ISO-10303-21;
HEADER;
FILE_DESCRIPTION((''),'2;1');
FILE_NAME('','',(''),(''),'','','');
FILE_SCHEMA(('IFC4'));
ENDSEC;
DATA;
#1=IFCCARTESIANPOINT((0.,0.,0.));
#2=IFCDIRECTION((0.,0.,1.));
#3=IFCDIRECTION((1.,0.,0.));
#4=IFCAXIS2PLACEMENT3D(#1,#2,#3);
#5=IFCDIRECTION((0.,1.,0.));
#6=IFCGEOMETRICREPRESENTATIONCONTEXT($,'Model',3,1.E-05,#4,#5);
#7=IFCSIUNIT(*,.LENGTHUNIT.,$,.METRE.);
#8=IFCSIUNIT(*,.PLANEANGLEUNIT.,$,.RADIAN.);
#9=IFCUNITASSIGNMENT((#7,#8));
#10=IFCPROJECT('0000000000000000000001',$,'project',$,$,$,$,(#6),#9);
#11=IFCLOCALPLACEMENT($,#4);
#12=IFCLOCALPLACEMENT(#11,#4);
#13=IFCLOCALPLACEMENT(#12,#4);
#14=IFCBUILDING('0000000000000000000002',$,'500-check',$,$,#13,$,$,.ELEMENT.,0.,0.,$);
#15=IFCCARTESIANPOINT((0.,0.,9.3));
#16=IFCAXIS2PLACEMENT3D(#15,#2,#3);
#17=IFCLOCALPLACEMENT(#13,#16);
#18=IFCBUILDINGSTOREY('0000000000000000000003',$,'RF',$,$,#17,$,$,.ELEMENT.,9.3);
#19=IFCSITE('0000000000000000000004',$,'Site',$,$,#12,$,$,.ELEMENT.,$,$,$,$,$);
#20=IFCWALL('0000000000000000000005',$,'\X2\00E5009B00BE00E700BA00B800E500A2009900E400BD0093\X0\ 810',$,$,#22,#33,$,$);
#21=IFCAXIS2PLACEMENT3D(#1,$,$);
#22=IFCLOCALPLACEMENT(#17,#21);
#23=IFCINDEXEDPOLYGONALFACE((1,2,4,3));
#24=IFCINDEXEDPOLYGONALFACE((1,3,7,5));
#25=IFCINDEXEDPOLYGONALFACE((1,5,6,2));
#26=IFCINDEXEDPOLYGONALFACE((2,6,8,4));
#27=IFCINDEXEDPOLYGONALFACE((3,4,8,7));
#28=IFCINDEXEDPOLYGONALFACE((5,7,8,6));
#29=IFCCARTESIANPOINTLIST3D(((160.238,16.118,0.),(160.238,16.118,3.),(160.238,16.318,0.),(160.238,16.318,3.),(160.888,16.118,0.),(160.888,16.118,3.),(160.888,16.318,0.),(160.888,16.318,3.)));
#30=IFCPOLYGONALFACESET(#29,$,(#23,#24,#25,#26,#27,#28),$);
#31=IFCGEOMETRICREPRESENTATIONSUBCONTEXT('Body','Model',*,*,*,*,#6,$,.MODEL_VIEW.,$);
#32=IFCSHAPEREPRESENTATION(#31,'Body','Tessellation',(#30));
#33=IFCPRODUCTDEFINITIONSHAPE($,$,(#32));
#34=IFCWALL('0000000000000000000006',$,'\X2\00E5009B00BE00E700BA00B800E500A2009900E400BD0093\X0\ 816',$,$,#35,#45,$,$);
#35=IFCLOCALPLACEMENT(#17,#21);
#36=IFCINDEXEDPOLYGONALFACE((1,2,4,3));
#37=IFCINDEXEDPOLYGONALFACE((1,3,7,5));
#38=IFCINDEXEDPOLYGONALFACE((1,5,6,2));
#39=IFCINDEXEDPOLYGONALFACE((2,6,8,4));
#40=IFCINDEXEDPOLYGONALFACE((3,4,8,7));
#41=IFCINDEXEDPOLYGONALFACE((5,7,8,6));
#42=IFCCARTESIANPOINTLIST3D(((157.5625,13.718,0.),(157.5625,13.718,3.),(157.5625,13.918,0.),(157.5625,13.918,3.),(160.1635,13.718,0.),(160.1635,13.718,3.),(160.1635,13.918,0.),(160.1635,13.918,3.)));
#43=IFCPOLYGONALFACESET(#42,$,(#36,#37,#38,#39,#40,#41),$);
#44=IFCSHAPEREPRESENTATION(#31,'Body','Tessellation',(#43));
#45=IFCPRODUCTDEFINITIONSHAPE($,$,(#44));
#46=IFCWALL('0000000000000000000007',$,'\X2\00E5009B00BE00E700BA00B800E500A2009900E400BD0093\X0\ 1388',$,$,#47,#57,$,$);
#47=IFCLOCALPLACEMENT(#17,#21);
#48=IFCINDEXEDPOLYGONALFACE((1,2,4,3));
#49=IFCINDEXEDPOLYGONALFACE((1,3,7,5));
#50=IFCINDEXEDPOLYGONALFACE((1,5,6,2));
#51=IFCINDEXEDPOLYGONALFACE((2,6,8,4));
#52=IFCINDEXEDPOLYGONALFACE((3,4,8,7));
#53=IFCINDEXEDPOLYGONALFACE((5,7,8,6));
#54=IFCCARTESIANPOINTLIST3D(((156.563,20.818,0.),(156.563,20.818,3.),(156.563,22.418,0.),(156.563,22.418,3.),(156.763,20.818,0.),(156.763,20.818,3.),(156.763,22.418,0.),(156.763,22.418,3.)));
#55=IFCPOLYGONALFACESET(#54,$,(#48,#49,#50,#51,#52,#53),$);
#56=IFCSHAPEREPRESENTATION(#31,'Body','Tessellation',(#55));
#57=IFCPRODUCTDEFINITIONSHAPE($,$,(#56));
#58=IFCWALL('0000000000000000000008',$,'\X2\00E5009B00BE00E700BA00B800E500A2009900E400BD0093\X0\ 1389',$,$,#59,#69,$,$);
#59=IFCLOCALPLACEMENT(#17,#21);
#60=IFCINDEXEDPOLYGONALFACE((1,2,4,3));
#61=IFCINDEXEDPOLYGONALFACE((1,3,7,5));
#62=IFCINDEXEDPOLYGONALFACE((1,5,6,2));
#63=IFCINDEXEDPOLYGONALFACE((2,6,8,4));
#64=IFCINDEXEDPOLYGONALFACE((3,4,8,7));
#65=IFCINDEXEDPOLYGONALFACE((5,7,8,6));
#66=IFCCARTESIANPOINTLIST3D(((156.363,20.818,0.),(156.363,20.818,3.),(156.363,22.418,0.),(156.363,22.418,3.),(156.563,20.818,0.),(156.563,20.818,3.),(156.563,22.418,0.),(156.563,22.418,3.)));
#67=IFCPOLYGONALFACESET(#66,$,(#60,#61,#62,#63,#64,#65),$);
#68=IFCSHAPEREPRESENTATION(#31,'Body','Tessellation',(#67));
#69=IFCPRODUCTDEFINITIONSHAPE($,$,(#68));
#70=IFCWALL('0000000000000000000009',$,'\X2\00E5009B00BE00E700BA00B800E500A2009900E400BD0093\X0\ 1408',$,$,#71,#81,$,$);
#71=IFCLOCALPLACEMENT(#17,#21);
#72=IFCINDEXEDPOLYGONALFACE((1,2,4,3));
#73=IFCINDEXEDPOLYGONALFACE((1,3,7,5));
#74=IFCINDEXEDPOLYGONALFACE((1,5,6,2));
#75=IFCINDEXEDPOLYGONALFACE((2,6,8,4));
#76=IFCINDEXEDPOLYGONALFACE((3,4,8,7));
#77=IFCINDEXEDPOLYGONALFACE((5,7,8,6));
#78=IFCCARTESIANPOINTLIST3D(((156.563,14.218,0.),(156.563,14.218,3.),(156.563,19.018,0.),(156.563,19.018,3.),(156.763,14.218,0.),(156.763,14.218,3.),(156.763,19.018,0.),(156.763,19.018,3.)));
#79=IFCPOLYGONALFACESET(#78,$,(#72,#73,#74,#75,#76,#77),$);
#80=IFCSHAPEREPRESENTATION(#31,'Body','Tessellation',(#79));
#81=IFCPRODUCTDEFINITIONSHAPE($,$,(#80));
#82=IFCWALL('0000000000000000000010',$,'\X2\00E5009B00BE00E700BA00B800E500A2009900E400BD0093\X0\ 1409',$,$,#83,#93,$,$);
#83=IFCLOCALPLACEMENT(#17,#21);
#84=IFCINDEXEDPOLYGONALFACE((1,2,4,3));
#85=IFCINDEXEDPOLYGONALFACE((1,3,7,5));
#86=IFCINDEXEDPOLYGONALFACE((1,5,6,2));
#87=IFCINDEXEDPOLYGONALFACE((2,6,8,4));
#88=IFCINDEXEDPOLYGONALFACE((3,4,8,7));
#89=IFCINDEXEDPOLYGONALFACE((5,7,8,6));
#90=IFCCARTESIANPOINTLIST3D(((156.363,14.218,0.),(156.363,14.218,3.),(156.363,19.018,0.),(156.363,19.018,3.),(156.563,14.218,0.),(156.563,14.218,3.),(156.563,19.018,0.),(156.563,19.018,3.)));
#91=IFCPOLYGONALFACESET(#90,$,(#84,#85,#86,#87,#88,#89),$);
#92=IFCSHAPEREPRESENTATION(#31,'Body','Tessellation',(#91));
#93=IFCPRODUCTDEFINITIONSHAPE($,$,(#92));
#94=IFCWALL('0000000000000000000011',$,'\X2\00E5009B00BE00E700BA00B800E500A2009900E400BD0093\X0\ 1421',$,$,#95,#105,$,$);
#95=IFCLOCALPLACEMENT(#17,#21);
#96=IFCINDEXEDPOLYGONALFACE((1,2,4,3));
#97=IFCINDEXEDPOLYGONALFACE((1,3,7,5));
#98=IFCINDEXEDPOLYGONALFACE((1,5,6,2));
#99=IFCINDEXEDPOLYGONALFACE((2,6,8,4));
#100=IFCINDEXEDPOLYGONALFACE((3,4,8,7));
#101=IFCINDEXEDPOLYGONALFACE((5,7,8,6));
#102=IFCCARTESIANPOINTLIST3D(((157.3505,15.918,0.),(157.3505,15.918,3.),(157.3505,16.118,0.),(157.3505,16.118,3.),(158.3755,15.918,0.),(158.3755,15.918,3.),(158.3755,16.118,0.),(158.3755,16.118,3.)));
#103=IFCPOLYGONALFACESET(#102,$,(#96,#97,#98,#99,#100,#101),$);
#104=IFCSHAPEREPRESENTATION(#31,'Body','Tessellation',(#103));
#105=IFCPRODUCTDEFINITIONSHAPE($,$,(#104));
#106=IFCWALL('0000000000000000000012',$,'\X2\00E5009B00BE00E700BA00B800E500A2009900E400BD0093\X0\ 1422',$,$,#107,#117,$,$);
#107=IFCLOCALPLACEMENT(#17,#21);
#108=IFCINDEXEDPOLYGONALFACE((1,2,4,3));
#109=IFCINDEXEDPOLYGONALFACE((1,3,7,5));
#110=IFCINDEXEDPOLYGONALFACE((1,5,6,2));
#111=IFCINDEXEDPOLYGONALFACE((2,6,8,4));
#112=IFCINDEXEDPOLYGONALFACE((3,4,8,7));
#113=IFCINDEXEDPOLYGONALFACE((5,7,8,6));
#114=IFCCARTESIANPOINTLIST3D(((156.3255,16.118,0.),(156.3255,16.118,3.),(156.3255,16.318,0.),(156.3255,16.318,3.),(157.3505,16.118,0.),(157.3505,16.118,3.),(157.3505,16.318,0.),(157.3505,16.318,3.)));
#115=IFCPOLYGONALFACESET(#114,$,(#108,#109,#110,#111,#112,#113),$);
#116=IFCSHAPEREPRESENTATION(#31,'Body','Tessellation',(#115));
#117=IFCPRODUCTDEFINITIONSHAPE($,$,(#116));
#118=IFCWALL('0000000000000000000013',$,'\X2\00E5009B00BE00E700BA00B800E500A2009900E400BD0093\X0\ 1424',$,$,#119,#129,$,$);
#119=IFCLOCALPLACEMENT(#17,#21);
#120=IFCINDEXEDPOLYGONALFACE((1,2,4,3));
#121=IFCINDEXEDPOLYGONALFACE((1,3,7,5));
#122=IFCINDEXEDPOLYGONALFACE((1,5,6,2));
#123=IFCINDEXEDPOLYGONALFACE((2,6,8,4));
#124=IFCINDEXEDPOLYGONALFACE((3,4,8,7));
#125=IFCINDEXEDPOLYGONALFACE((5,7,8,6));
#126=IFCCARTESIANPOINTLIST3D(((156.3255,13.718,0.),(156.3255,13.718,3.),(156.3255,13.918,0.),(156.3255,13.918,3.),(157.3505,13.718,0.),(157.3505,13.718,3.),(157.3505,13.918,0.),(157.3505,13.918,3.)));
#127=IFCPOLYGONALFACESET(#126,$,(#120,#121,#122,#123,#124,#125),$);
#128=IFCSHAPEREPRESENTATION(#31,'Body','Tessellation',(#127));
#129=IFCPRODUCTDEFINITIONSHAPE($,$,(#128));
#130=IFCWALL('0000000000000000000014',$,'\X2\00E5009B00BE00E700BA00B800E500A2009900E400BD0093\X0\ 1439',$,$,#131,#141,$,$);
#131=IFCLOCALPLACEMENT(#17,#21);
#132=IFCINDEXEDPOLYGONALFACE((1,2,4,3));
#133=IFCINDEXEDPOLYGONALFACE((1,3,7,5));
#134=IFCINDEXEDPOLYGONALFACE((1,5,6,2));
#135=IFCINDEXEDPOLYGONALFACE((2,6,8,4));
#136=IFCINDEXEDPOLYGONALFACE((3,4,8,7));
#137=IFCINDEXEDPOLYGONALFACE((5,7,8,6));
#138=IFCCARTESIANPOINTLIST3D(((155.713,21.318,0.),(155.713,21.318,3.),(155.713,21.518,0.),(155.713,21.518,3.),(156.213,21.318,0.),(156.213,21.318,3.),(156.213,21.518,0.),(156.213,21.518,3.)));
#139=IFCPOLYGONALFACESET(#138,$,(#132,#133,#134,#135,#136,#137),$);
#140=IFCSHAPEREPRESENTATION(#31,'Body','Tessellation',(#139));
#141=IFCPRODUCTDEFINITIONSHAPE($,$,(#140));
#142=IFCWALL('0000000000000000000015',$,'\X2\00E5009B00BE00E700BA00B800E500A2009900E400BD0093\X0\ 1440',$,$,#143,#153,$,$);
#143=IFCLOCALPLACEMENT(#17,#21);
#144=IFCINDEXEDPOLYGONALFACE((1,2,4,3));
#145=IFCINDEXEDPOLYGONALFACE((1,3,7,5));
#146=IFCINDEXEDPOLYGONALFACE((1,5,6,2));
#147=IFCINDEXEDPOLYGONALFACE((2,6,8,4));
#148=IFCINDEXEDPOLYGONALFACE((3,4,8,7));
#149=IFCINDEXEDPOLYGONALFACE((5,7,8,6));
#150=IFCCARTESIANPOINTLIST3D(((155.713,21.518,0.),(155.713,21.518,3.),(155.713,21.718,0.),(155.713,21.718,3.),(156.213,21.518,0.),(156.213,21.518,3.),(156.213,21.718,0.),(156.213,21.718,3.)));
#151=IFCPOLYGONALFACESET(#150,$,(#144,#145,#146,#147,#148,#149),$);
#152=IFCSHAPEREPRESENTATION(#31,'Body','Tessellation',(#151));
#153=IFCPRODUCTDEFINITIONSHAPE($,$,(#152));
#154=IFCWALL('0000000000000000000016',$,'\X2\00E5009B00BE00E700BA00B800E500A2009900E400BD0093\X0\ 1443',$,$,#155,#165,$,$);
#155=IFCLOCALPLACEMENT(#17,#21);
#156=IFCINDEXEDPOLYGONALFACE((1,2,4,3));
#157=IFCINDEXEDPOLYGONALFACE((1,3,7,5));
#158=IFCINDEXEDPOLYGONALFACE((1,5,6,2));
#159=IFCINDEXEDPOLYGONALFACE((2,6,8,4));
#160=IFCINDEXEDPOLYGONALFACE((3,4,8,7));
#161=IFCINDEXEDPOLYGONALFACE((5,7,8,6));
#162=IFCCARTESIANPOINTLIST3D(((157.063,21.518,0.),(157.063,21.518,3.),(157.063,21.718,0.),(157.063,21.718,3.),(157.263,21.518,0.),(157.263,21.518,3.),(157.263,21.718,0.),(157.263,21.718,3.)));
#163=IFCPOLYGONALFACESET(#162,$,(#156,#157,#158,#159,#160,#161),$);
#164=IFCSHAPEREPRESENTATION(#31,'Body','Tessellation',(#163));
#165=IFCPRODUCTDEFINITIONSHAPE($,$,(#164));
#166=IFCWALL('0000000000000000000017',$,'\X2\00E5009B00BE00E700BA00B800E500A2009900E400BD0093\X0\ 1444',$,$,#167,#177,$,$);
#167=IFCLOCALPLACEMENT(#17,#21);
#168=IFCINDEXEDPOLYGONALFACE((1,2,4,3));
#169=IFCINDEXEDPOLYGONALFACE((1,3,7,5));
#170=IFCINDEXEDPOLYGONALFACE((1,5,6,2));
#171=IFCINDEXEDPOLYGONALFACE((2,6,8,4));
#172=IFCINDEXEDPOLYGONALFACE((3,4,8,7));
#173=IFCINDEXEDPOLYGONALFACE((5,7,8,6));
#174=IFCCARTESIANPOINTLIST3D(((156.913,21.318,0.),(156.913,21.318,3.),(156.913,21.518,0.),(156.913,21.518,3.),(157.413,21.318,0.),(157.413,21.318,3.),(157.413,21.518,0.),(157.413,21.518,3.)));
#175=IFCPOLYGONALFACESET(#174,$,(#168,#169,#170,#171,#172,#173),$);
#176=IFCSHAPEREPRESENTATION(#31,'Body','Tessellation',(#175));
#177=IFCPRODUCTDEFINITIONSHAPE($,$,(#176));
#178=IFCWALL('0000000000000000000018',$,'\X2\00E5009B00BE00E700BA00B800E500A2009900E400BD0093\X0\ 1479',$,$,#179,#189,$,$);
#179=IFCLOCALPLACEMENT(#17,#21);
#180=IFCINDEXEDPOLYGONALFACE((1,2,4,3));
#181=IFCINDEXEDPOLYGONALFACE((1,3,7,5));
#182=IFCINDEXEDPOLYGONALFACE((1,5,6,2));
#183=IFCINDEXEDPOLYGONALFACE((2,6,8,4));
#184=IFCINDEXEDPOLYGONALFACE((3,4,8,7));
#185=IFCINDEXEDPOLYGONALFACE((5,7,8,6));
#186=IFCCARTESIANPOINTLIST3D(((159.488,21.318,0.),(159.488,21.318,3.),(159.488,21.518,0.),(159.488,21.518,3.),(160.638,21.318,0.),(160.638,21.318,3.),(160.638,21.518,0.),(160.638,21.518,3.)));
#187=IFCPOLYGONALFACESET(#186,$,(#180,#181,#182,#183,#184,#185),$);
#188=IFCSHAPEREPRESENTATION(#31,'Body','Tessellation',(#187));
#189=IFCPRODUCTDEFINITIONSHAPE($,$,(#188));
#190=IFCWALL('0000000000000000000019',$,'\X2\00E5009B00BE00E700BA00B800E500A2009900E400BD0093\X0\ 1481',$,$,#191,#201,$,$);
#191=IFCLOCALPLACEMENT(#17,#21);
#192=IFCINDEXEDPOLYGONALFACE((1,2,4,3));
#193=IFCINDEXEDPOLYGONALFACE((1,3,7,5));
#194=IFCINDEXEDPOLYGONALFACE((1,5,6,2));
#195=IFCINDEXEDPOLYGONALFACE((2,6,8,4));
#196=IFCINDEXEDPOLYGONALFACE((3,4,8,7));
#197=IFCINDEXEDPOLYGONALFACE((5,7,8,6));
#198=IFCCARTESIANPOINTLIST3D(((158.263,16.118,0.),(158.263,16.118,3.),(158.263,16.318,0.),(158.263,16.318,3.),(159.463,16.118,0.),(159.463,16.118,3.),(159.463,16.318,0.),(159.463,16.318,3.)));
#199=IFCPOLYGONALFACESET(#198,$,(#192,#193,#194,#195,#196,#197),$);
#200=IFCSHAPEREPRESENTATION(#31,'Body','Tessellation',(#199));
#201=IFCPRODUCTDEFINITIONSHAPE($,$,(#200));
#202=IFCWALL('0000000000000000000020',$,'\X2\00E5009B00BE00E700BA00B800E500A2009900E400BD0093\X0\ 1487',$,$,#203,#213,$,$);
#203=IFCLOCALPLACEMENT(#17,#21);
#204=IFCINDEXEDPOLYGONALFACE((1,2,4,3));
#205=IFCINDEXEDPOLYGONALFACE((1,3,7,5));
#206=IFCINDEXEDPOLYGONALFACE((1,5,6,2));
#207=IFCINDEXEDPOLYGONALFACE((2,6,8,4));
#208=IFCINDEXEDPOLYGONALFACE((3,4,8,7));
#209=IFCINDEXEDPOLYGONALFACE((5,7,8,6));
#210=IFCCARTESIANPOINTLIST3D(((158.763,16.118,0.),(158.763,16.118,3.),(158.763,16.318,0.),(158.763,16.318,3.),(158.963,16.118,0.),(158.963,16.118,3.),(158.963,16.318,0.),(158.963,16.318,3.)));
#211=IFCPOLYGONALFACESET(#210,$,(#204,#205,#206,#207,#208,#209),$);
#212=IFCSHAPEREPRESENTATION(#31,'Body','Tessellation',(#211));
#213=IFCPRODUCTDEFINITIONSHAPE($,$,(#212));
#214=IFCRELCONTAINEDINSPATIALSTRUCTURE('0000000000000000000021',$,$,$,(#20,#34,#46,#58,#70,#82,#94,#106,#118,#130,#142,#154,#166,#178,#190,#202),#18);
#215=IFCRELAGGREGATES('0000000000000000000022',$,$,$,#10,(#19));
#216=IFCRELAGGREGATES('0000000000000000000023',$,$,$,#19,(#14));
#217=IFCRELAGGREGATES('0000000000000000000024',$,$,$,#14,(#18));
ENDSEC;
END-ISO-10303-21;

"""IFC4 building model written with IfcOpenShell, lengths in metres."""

from ifc_helpers import new_model, si_unit, direction, frame, frame_2d, origin_with_axes, place, context, subcontext, project, spatial, rectangle, extrude, element, save


model = new_model("IFC4")

# Units and contexts
model_context = context("Model", 3, precision=1e-05, world=origin_with_axes(), true_north=direction((0.0, 1.0, 0.0)))
body_context = subcontext(model_context, "Body", "Model", "MODEL_VIEW")
ifc_project = project(units=[si_unit("LENGTHUNIT", "METRE"), si_unit("PLANEANGLEUNIT", "RADIAN")], contexts=[model_context])

# Site, building, storey
placement = place(None, origin_with_axes())
site_placement = place(placement, origin_with_axes())
site = spatial("IfcSite", under=ifc_project, at=site_placement, Name="Site", CompositionType="ELEMENT")
building_placement = place(site_placement, origin_with_axes())
building = spatial("IfcBuilding", under=site, at=building_placement, Name="500-check", CompositionType="ELEMENT", ElevationOfRefHeight=0.0, ElevationOfTerrain=0.0)
storey_placement = place(building_placement, frame((0.0, 0.0, 9.3), z_axis=(0.0, 0.0, 1.0), x_axis=(1.0, 0.0, 0.0)))
storey = spatial("IfcBuildingStorey", under=building, at=storey_placement, Name="RF", CompositionType="ELEMENT", Elevation=9.3)

# Walls
wall_1_placement = place(storey_placement, frame((160.563, 16.218, 0.0), z_axis=(0.0, 0.0, 1.0), x_axis=(1.0, 0.0, 0.0)))
element("IfcWall", 1, at=wall_1_placement, inside=storey, Name="å\u009b¾çº¸å¢\u0099ä½\u0093 810", context=body_context, shape_type="SweptSolid", body=[
    extrude(rectangle(XDim=0.65, YDim=0.2, at=frame_2d((0.0, 0.0), x_axis=(1.0, 0.0, 0.0))), frame((0.0, 0.0, 0.0), z_axis=(0.0, 0.0, 1.0)), (0.0, 0.0, 1.0), 3.0),
])
wall_2_placement = place(storey_placement, frame((158.863, 13.818, 0.0), z_axis=(0.0, 0.0, 1.0), x_axis=(1.0, 0.0, 0.0)))
element("IfcWall", 2, at=wall_2_placement, inside=storey, Name="å\u009b¾çº¸å¢\u0099ä½\u0093 816", context=body_context, shape_type="SweptSolid", body=[
    extrude(rectangle(XDim=2.601, YDim=0.2, at=frame_2d((0.0, 0.0), x_axis=(1.0, 0.0, 0.0))), frame((0.0, 0.0, 0.0), z_axis=(0.0, 0.0, 1.0)), (0.0, 0.0, 1.0), 3.0),
])
for number, where, z_axis, x_axis, name in (
    (3, (156.663, 21.618, 0.0), (0.0, 0.0, 1.0), (0.0, 1.0, 0.0), "å\u009b¾çº¸å¢\u0099ä½\u0093 1388"),
    (4, (156.463, 21.618, 0.0), (0.0, 0.0, 1.0), (0.0, 1.0, 0.0), "å\u009b¾çº¸å¢\u0099ä½\u0093 1389"),
):
    element("IfcWall", number, at=place(storey_placement, frame(where, z_axis=z_axis, x_axis=x_axis)), inside=storey, Name=name, context=body_context, shape_type="SweptSolid", body=[
        extrude(rectangle(XDim=1.6, YDim=0.2, at=frame_2d((0.0, 0.0), x_axis=(1.0, 0.0, 0.0))), frame((0.0, 0.0, 0.0), z_axis=(0.0, 0.0, 1.0)), (0.0, 0.0, 1.0), 3.0),
    ])
for number, where, z_axis, x_axis, name in (
    (5, (156.663, 16.618, 0.0), (0.0, 0.0, 1.0), (0.0, 1.0, 0.0), "å\u009b¾çº¸å¢\u0099ä½\u0093 1408"),
    (6, (156.463, 16.618, 0.0), (0.0, 0.0, 1.0), (0.0, 1.0, 0.0), "å\u009b¾çº¸å¢\u0099ä½\u0093 1409"),
):
    element("IfcWall", number, at=place(storey_placement, frame(where, z_axis=z_axis, x_axis=x_axis)), inside=storey, Name=name, context=body_context, shape_type="SweptSolid", body=[
        extrude(rectangle(XDim=4.8, YDim=0.2, at=frame_2d((0.0, 0.0), x_axis=(1.0, 0.0, 0.0))), frame((0.0, 0.0, 0.0), z_axis=(0.0, 0.0, 1.0)), (0.0, 0.0, 1.0), 3.0),
    ])
for number, where, z_axis, x_axis, name in (
    (7, (157.863, 16.018, 0.0), (0.0, 0.0, 1.0), (-1.0, 0.0, 0.0), "å\u009b¾çº¸å¢\u0099ä½\u0093 1421"),
    (8, (156.838, 16.218, 0.0), (0.0, 0.0, 1.0), (1.0, 0.0, 0.0), "å\u009b¾çº¸å¢\u0099ä½\u0093 1422"),
    (9, (156.838, 13.818, 0.0), (0.0, 0.0, 1.0), (1.0, 0.0, 0.0), "å\u009b¾çº¸å¢\u0099ä½\u0093 1424"),
):
    element("IfcWall", number, at=place(storey_placement, frame(where, z_axis=z_axis, x_axis=x_axis)), inside=storey, Name=name, context=body_context, shape_type="SweptSolid", body=[
        extrude(rectangle(XDim=1.025, YDim=0.2, at=frame_2d((0.0, 0.0), x_axis=(1.0, 0.0, 0.0))), frame((0.0, 0.0, 0.0), z_axis=(0.0, 0.0, 1.0)), (0.0, 0.0, 1.0), 3.0),
    ])
for number, where, z_axis, x_axis, name in (
    (10, (155.963, 21.418, 0.0), (0.0, 0.0, 1.0), (1.0, 0.0, 0.0), "å\u009b¾çº¸å¢\u0099ä½\u0093 1439"),
    (11, (155.963, 21.618, 0.0), (0.0, 0.0, 1.0), (1.0, 0.0, 0.0), "å\u009b¾çº¸å¢\u0099ä½\u0093 1440"),
):
    element("IfcWall", number, at=place(storey_placement, frame(where, z_axis=z_axis, x_axis=x_axis)), inside=storey, Name=name, context=body_context, shape_type="SweptSolid", body=[
        extrude(rectangle(XDim=0.5, YDim=0.2, at=frame_2d((0.0, 0.0), x_axis=(1.0, 0.0, 0.0))), frame((0.0, 0.0, 0.0), z_axis=(0.0, 0.0, 1.0)), (0.0, 0.0, 1.0), 3.0),
    ])
wall_3_placement = place(storey_placement, frame((157.163, 21.618, 0.0), z_axis=(0.0, 0.0, 1.0), x_axis=(0.0, -1.0, 0.0)))
element("IfcWall", 12, at=wall_3_placement, inside=storey, Name="å\u009b¾çº¸å¢\u0099ä½\u0093 1443", context=body_context, shape_type="SweptSolid", body=[
    extrude(rectangle(XDim=0.2, YDim=0.2, at=frame_2d((0.0, 0.0), x_axis=(1.0, 0.0, 0.0))), frame((0.0, 0.0, 0.0), z_axis=(0.0, 0.0, 1.0)), (0.0, 0.0, 1.0), 3.0),
])
wall_4_placement = place(storey_placement, frame((157.163, 21.418, 0.0), z_axis=(0.0, 0.0, 1.0), x_axis=(-1.0, 0.0, 0.0)))
element("IfcWall", 13, at=wall_4_placement, inside=storey, Name="å\u009b¾çº¸å¢\u0099ä½\u0093 1444", context=body_context, shape_type="SweptSolid", body=[
    extrude(rectangle(XDim=0.5, YDim=0.2, at=frame_2d((0.0, 0.0), x_axis=(1.0, 0.0, 0.0))), frame((0.0, 0.0, 0.0), z_axis=(0.0, 0.0, 1.0)), (0.0, 0.0, 1.0), 3.0),
])
wall_5_placement = place(storey_placement, frame((160.063, 21.418, 0.0), z_axis=(0.0, 0.0, 1.0), x_axis=(-1.0, 0.0, 0.0)))
element("IfcWall", 14, at=wall_5_placement, inside=storey, Name="å\u009b¾çº¸å¢\u0099ä½\u0093 1479", context=body_context, shape_type="SweptSolid", body=[
    extrude(rectangle(XDim=1.15, YDim=0.2, at=frame_2d((0.0, 0.0), x_axis=(1.0, 0.0, 0.0))), frame((0.0, 0.0, 0.0), z_axis=(0.0, 0.0, 1.0)), (0.0, 0.0, 1.0), 3.0),
])
wall_6_placement = place(storey_placement, frame((158.863, 16.218, 0.0), z_axis=(0.0, 0.0, 1.0), x_axis=(1.0, 0.0, 0.0)))
element("IfcWall", 15, at=wall_6_placement, inside=storey, Name="å\u009b¾çº¸å¢\u0099ä½\u0093 1481", context=body_context, shape_type="SweptSolid", body=[
    extrude(rectangle(XDim=1.2, YDim=0.2, at=frame_2d((0.0, 0.0), x_axis=(1.0, 0.0, 0.0))), frame((0.0, 0.0, 0.0), z_axis=(0.0, 0.0, 1.0)), (0.0, 0.0, 1.0), 3.0),
])
for number, where, z_axis, x_axis, name in (
    (16, (158.863, 16.218, 0.0), (0.0, 0.0, 1.0), (0.0, -1.0, 0.0), "å\u009b¾çº¸å¢\u0099ä½\u0093 1487"),
):
    element("IfcWall", number, at=place(storey_placement, frame(where, z_axis=z_axis, x_axis=x_axis)), inside=storey, Name=name, context=body_context, shape_type="SweptSolid", body=[
        extrude(rectangle(XDim=0.2, YDim=0.2, at=frame_2d((0.0, 0.0), x_axis=(1.0, 0.0, 0.0))), frame((0.0, 0.0, 0.0), z_axis=(0.0, 0.0, 1.0)), (0.0, 0.0, 1.0), 3.0),
    ])

save(model, "model.ifc")
